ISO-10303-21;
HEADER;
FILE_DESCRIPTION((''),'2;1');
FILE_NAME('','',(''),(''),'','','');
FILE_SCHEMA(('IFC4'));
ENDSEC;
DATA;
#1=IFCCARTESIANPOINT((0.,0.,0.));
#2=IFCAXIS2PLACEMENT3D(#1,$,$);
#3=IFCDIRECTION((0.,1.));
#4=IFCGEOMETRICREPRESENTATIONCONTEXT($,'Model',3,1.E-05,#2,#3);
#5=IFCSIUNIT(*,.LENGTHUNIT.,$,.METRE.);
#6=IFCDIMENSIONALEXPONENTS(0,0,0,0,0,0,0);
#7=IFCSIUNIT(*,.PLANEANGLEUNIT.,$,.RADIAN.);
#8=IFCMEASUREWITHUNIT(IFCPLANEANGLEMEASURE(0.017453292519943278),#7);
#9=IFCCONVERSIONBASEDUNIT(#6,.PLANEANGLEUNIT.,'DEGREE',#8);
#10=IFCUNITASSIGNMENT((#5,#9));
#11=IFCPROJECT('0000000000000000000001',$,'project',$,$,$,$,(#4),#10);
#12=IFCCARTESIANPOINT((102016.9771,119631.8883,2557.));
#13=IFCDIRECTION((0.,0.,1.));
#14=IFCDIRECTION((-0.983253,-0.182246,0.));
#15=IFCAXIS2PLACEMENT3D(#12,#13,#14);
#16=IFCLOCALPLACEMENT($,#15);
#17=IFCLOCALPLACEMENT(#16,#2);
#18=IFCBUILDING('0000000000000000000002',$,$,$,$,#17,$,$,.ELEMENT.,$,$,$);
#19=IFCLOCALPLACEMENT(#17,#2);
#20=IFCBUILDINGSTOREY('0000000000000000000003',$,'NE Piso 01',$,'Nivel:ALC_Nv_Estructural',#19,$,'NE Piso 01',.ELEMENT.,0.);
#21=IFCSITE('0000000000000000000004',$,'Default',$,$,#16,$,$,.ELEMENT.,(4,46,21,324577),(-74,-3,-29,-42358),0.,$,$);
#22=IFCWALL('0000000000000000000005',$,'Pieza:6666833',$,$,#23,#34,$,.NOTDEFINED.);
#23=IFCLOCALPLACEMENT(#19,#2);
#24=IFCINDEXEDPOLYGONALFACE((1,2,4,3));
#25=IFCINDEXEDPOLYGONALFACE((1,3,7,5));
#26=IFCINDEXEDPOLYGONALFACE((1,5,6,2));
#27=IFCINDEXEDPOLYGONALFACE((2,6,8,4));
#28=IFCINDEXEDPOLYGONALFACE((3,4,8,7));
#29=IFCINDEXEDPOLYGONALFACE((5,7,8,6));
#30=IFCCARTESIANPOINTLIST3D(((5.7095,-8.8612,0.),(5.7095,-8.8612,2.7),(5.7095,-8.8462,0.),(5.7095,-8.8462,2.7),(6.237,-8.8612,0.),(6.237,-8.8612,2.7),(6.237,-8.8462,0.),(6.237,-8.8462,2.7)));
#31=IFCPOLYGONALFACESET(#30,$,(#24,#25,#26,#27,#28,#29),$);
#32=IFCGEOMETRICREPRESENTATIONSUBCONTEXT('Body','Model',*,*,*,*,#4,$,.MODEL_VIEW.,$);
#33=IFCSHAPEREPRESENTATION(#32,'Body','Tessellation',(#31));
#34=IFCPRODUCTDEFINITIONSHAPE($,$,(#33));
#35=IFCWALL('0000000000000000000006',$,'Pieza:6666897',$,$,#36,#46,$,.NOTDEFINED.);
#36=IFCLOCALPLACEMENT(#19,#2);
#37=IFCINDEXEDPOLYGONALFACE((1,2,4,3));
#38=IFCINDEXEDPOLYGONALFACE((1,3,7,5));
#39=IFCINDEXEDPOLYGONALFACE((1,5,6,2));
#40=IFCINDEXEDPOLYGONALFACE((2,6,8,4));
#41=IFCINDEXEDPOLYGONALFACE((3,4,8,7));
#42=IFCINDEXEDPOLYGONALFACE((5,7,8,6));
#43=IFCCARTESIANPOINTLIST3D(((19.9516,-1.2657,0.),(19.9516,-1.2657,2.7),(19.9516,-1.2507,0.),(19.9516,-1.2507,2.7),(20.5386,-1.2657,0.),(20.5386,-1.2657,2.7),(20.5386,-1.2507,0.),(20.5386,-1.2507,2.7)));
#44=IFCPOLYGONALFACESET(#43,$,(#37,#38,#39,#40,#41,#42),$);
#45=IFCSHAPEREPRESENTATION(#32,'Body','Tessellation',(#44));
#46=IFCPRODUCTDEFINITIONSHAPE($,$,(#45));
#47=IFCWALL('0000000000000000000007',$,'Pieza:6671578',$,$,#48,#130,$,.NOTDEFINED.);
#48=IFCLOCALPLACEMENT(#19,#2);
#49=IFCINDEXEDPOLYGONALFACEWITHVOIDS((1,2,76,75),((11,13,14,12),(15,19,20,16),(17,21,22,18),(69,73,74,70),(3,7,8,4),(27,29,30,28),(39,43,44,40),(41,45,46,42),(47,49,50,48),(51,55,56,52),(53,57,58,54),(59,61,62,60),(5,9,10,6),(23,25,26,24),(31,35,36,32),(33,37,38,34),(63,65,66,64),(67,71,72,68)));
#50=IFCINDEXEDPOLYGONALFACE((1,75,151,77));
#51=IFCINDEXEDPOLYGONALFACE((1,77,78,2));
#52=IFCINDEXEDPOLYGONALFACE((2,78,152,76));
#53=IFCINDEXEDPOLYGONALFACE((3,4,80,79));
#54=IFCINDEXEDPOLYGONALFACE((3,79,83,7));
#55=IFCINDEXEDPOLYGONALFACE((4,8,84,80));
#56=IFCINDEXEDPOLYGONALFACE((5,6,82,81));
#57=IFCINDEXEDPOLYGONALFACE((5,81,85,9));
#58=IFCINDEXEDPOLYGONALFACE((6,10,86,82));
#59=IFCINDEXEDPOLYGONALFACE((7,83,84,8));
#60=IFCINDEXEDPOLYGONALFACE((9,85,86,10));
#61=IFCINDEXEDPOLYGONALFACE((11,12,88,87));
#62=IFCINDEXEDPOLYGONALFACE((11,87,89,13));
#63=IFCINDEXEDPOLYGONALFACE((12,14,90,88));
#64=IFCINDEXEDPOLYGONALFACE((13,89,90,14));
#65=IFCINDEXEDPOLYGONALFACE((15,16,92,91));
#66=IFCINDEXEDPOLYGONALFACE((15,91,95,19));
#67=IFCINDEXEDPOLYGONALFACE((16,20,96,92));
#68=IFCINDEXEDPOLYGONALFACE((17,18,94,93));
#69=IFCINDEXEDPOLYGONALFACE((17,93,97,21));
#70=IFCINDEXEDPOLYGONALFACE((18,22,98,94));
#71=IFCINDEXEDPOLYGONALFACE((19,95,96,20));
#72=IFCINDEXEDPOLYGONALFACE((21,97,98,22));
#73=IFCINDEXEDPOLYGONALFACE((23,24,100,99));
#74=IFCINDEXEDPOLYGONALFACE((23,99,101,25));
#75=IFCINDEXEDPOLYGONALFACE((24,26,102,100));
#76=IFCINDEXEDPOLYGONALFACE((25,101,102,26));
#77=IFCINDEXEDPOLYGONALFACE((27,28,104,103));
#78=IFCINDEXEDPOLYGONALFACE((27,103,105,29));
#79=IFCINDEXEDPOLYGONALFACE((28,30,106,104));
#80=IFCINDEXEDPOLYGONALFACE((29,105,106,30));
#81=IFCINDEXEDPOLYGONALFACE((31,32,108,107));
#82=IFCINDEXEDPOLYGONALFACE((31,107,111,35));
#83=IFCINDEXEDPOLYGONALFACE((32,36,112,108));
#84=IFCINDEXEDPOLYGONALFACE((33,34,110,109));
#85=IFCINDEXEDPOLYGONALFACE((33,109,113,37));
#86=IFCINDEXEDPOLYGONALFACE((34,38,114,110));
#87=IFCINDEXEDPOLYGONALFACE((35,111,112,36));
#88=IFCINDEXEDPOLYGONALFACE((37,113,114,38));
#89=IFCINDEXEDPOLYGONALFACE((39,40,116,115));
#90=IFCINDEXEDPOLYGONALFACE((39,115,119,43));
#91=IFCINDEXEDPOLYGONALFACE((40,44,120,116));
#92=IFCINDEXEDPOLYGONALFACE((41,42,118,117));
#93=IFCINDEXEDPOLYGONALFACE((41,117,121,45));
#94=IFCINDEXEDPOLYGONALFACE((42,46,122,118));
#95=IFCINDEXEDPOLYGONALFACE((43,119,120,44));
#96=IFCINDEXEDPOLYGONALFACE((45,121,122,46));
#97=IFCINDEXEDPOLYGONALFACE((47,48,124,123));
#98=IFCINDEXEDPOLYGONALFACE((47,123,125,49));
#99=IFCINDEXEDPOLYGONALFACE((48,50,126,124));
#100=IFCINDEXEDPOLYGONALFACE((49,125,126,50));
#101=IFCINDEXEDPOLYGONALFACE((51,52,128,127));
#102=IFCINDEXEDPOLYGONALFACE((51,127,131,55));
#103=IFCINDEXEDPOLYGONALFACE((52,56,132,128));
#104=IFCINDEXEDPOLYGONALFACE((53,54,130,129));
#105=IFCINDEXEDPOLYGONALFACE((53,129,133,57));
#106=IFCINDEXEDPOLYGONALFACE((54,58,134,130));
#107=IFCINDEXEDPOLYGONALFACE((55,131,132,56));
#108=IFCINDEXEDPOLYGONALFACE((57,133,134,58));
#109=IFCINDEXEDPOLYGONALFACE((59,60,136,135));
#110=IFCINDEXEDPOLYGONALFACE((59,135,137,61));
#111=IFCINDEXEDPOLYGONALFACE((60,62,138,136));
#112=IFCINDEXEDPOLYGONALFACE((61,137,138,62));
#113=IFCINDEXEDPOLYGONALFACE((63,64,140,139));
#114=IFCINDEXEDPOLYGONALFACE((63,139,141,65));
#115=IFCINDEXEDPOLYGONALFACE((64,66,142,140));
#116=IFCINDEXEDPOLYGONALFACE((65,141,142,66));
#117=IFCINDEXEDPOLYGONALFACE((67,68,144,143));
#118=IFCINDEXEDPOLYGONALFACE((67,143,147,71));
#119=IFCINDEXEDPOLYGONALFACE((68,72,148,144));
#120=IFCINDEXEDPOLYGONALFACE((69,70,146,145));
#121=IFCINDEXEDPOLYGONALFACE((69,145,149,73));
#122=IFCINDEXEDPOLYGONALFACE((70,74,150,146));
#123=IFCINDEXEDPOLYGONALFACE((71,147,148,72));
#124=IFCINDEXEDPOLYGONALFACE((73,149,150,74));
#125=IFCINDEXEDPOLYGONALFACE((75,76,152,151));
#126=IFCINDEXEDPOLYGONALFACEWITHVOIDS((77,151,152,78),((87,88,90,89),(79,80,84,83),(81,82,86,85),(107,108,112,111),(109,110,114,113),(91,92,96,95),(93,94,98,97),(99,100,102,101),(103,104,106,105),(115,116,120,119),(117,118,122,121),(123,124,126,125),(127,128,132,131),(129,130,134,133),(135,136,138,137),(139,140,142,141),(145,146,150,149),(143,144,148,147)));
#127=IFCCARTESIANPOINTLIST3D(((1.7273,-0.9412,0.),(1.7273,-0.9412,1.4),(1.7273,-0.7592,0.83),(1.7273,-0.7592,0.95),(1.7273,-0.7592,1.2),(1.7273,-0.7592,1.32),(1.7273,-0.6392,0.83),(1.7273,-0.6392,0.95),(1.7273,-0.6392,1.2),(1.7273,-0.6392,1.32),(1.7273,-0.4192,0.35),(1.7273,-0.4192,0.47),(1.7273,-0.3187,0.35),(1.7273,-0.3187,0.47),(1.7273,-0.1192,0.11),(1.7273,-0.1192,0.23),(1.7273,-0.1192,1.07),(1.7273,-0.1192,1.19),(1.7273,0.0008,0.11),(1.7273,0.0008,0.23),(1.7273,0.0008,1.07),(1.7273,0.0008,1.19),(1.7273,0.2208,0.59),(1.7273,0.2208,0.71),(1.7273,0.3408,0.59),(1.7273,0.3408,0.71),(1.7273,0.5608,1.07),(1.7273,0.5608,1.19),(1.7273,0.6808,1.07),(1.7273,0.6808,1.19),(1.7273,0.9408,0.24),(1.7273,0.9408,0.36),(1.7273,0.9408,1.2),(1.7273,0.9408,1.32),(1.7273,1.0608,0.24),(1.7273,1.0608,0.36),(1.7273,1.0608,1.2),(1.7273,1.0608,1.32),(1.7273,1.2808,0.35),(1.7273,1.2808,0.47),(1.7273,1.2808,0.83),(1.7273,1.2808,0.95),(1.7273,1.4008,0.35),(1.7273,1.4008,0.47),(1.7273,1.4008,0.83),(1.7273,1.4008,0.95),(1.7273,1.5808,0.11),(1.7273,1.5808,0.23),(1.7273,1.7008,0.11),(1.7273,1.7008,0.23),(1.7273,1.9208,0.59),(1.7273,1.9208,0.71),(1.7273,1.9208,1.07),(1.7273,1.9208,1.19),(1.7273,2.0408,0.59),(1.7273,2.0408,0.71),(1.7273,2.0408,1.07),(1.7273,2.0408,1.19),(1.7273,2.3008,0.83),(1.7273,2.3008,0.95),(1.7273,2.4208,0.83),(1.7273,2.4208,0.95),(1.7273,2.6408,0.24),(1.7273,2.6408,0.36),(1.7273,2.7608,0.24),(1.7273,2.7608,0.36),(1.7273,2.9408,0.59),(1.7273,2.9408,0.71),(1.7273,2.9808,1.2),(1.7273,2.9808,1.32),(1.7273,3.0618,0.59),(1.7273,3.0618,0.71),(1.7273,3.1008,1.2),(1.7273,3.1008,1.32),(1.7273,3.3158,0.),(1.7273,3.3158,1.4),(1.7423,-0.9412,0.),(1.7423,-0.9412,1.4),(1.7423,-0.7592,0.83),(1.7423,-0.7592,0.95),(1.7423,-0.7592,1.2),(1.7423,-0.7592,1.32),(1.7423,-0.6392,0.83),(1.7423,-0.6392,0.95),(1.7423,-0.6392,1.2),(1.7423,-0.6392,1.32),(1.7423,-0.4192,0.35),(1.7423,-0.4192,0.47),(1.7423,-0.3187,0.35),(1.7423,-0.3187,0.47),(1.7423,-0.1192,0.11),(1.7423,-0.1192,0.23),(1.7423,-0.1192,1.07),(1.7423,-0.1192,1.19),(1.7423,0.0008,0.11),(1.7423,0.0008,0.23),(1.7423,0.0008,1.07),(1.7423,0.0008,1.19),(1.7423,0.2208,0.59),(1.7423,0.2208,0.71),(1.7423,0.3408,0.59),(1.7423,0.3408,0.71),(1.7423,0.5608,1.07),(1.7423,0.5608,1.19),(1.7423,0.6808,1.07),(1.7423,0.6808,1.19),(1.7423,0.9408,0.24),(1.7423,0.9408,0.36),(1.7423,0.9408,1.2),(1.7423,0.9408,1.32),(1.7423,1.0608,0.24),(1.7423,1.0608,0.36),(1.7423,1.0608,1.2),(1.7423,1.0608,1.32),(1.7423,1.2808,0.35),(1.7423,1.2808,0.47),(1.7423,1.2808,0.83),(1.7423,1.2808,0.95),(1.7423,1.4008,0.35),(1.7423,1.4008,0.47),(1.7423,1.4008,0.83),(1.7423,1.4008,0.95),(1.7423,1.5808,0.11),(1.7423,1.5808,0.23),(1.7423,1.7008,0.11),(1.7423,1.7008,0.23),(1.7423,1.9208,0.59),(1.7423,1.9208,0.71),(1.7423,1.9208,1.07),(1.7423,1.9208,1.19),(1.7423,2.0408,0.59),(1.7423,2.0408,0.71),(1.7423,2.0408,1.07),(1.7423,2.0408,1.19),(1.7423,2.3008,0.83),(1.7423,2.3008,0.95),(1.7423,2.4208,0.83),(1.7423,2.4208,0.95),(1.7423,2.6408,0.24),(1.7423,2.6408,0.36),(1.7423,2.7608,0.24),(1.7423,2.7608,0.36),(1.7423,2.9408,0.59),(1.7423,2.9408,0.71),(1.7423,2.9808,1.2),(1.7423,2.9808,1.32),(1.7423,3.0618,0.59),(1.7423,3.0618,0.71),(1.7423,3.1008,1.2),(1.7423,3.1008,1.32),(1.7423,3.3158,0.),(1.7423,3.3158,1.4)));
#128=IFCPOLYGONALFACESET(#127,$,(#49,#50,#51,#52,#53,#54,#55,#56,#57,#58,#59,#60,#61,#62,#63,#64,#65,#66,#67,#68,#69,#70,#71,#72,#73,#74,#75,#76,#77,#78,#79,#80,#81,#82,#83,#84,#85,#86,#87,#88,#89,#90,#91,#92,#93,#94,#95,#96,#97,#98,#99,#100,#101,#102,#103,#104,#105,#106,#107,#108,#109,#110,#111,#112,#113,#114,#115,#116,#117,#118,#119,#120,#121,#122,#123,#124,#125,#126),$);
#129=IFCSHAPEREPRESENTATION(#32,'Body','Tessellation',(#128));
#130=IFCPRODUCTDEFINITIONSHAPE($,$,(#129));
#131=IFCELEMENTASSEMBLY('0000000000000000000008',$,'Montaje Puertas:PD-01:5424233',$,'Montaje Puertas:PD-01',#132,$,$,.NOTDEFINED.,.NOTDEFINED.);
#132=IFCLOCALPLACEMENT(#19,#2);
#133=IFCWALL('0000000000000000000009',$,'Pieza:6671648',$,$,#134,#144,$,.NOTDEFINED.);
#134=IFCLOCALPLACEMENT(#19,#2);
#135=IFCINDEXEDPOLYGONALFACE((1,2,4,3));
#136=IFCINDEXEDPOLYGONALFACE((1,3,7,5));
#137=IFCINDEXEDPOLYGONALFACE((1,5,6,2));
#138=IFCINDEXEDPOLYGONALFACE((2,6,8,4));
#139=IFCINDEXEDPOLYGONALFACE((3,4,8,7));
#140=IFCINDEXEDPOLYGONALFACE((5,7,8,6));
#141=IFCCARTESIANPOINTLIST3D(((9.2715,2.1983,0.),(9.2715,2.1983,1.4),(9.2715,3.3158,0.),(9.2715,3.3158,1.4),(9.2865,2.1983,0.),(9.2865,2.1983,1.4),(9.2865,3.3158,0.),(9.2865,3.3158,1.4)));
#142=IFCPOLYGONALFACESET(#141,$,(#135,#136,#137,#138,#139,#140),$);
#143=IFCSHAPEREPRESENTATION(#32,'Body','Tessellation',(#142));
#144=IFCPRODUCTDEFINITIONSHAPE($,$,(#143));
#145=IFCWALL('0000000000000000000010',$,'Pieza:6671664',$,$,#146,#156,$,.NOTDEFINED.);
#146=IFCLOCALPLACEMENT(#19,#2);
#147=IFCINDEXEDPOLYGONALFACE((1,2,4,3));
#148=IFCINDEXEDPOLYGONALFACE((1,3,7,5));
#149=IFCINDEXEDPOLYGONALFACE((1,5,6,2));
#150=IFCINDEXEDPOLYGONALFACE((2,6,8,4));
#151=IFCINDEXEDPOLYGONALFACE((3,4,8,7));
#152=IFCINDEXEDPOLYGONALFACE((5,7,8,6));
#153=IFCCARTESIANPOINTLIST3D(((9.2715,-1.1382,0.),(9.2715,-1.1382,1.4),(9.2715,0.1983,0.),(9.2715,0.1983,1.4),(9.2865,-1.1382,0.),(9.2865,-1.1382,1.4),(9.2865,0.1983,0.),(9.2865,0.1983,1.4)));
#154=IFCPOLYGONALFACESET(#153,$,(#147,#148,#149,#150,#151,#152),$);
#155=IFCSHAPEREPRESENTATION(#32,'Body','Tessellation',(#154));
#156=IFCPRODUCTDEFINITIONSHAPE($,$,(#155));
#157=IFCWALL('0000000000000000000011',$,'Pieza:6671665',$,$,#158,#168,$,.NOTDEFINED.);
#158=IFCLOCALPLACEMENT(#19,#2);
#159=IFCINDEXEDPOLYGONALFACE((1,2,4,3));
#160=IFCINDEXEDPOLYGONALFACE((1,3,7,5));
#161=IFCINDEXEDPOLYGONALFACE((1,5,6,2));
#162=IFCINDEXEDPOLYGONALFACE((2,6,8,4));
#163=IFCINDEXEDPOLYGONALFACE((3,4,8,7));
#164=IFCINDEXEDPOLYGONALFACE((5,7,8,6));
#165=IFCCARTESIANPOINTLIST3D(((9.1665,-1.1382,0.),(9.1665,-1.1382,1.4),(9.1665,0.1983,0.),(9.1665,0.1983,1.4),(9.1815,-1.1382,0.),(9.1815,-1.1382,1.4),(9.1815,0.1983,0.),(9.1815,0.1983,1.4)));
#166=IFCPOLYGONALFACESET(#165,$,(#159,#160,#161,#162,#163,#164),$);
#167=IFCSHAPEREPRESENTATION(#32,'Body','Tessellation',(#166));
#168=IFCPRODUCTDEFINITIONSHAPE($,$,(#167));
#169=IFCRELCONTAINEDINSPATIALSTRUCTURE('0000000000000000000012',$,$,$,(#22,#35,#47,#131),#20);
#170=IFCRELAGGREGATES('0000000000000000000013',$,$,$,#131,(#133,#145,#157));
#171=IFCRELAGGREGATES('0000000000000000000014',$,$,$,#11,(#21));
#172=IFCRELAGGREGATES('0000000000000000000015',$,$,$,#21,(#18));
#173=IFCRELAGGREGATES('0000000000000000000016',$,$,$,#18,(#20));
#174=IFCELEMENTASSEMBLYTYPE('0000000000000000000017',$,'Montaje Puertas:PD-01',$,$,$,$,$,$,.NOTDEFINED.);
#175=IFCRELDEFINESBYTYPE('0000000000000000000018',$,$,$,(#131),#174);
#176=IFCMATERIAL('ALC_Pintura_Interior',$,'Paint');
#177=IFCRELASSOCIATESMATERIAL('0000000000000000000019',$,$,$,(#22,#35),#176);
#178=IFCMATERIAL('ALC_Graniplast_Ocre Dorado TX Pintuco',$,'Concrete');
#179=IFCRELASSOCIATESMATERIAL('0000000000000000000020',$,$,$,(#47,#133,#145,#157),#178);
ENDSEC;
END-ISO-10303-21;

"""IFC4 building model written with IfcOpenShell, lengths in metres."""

from ifc_helpers import new_model, entity, si_unit, converted_unit, direction, frame, frame_2d, origin, origin_2d_with_axis, place, context, subcontext, project, spatial, rectangle, extrude, boolean, material, type_object, element, aggregate, save


model = new_model("IFC4")

# Units and contexts
model_context = context("Model", 3, precision=1e-05, world=origin(), true_north=direction((0.0, 1.0)))
body_context = subcontext(model_context, "Body", "Model", "MODEL_VIEW")
ifc_project = project(units=[si_unit("LENGTHUNIT", "METRE"), converted_unit("PLANEANGLEUNIT", "DEGREE", entity("IfcPlaneAngleMeasure", 0.017453292519943278), si_unit("PLANEANGLEUNIT", "RADIAN"), dimensions=[0, 0, 0, 0, 0, 0, 0])], contexts=[model_context])

# Site, building, storey
site_placement = place(None, frame((102016.9771, 119631.8883, 2557.0), z_axis=(0.0, 0.0, 1.0), x_axis=(-0.983253, -0.182246, 0.0)))
site = spatial("IfcSite", under=ifc_project, at=site_placement, Name="Default", CompositionType="ELEMENT", RefLatitude=(4, 46, 21, 324577), RefLongitude=(-74, -3, -29, -42358), RefElevation=0.0)
building_placement = place(site_placement, origin())
building = spatial("IfcBuilding", under=site, at=building_placement, CompositionType="ELEMENT")
storey_placement = place(building_placement, origin())
storey = spatial("IfcBuildingStorey", under=building, at=storey_placement, Name="NE Piso 01", ObjectType="Nivel:ALC_Nv_Estructural", LongName="NE Piso 01", CompositionType="ELEMENT", Elevation=0.0)

# Walls
ifc_material_1 = material(Name="ALC_Pintura_Interior", Category="Paint")
wall_1_placement = place(storey_placement, origin())
element("IfcWall", 1, at=wall_1_placement, inside=storey, material=ifc_material_1, Name="Pieza:6666833", PredefinedType="NOTDEFINED", context=body_context, shape_type="SweptSolid", body=[
    extrude(rectangle(XDim=0.015, YDim=0.5275, at=frame_2d((0.0, 0.0), x_axis=(1.0, 0.0))), frame((5.9733, -8.8537, 0.0), z_axis=(0.0, 0.0, 1.0), x_axis=(0.0, -1.0, 0.0)), (0.0, 0.0, 1.0), 2.7),
])
wall_2_placement = place(storey_placement, origin())
element("IfcWall", 2, at=wall_2_placement, inside=storey, material=ifc_material_1, Name="Pieza:6666897", PredefinedType="NOTDEFINED", context=body_context, shape_type="SweptSolid", body=[
    extrude(rectangle(XDim=0.015, YDim=0.587, at=frame_2d((0.0, 0.0), x_axis=(1.0, 0.0))), frame((20.2451, -1.2582, 0.0), z_axis=(0.0, 0.0, 1.0), x_axis=(0.0, -1.0, 0.0)), (0.0, 0.0, 1.0), 2.7),
])
ifc_material_2 = material(Name="ALC_Graniplast_Ocre Dorado TX Pintuco", Category="Concrete")
wall_3_placement = place(storey_placement, origin())
solid_1 = boolean("DIFFERENCE", boolean("DIFFERENCE", boolean("DIFFERENCE", boolean("DIFFERENCE", boolean("DIFFERENCE", boolean("DIFFERENCE", boolean("DIFFERENCE", boolean("DIFFERENCE", extrude(rectangle(XDim=0.015, YDim=4.257, at=origin_2d_with_axis()), frame((1.7348, 1.1873, 0.0)), (0.0, 0.0, 1.0), 1.4), extrude(rectangle(XDim=0.12, YDim=0.12, at=frame_2d((0.0, 0.0), x_axis=(0.0, 1.0))), frame((1.7273, -0.0592, 0.17), z_axis=(-1.0, 0.0, 0.0), x_axis=(0.0, 1.0, 0.0)), (0.0, 0.0, -1.0), 0.015)), extrude(rectangle(XDim=0.12, YDim=0.12, at=frame_2d((0.0, 0.0), x_axis=(0.0, 1.0))), frame((1.7273, 1.6408, 0.17), z_axis=(-1.0, 0.0, 0.0), x_axis=(0.0, 1.0, 0.0)), (0.0, 0.0, -1.0), 0.015)), extrude(rectangle(XDim=0.12, YDim=0.12, at=frame_2d((0.0, 0.0), x_axis=(0.0, 1.0))), frame((1.7273, 1.0008, 0.3), z_axis=(-1.0, 0.0, 0.0), x_axis=(0.0, 1.0, 0.0)), (0.0, 0.0, -1.0), 0.015)), extrude(rectangle(XDim=0.12, YDim=0.12, at=frame_2d((0.0, 0.0), x_axis=(0.0, 1.0))), frame((1.7273, 2.7008, 0.3), z_axis=(-1.0, 0.0, 0.0), x_axis=(0.0, 1.0, 0.0)), (0.0, 0.0, -1.0), 0.015)), extrude(rectangle(XDim=0.12, YDim=0.1005, at=frame_2d((0.0, 0.0), x_axis=(0.0, 1.0))), frame((1.7273, -0.3689, 0.41), z_axis=(-1.0, 0.0, 0.0), x_axis=(0.0, 1.0, 0.0)), (0.0, 0.0, -1.0), 0.015)), extrude(rectangle(XDim=0.12, YDim=0.12, at=frame_2d((0.0, 0.0), x_axis=(0.0, 1.0))), frame((1.7273, 1.3408, 0.41), z_axis=(-1.0, 0.0, 0.0), x_axis=(0.0, 1.0, 0.0)), (0.0, 0.0, -1.0), 0.015)), extrude(rectangle(XDim=0.12, YDim=0.12, at=frame_2d((0.0, 0.0), x_axis=(0.0, 1.0))), frame((1.7273, 0.2808, 0.65), z_axis=(-1.0, 0.0, 0.0), x_axis=(0.0, 1.0, 0.0)), (0.0, 0.0, -1.0), 0.015)), extrude(rectangle(XDim=0.12, YDim=0.12, at=frame_2d((0.0, 0.0), x_axis=(0.0, 1.0))), frame((1.7273, 1.9808, 0.65), z_axis=(1.0, 0.0, 0.0), x_axis=(0.0, -1.0, 0.0)), (0.0, 0.0, 1.0), 0.015))
solid_2 = boolean("DIFFERENCE", boolean("DIFFERENCE", boolean("DIFFERENCE", boolean("DIFFERENCE", boolean("DIFFERENCE", boolean("DIFFERENCE", boolean("DIFFERENCE", boolean("DIFFERENCE", solid_1, extrude(rectangle(XDim=0.12, YDim=0.121, at=frame_2d((0.0, 0.0), x_axis=(0.0, 1.0))), frame((1.7273, 3.0013, 0.65), z_axis=(-1.0, 0.0, 0.0), x_axis=(0.0, 1.0, 0.0)), (0.0, 0.0, -1.0), 0.015)), extrude(rectangle(XDim=0.12, YDim=0.12, at=frame_2d((0.0, 0.0), x_axis=(0.0, 1.0))), frame((1.7273, -0.6992, 0.89), z_axis=(1.0, 0.0, 0.0), x_axis=(0.0, -1.0, 0.0)), (0.0, 0.0, 1.0), 0.015)), extrude(rectangle(XDim=0.12, YDim=0.12, at=frame_2d((0.0, 0.0), x_axis=(0.0, 1.0))), frame((1.7273, 1.3408, 0.89), z_axis=(-1.0, 0.0, 0.0), x_axis=(0.0, 1.0, 0.0)), (0.0, 0.0, -1.0), 0.015)), extrude(rectangle(XDim=0.12, YDim=0.12, at=frame_2d((0.0, 0.0), x_axis=(0.0, 1.0))), frame((1.7273, 2.3608, 0.89), z_axis=(-1.0, 0.0, 0.0), x_axis=(0.0, 1.0, 0.0)), (0.0, 0.0, -1.0), 0.015)), extrude(rectangle(XDim=0.12, YDim=0.12, at=frame_2d((0.0, 0.0), x_axis=(0.0, 1.0))), frame((1.7273, -0.0592, 1.13), z_axis=(-1.0, 0.0, 0.0), x_axis=(0.0, 1.0, 0.0)), (0.0, 0.0, -1.0), 0.015)), extrude(rectangle(XDim=0.12, YDim=0.12, at=frame_2d((0.0, 0.0), x_axis=(0.0, 1.0))), frame((1.7273, 0.6208, 1.13), z_axis=(-1.0, 0.0, 0.0), x_axis=(0.0, 1.0, 0.0)), (0.0, 0.0, -1.0), 0.015)), extrude(rectangle(XDim=0.12, YDim=0.12, at=frame_2d((0.0, 0.0), x_axis=(0.0, 1.0))), frame((1.7273, 1.9808, 1.13), z_axis=(-1.0, 0.0, 0.0), x_axis=(0.0, 1.0, 0.0)), (0.0, 0.0, -1.0), 0.015)), extrude(rectangle(XDim=0.12, YDim=0.12, at=frame_2d((0.0, 0.0), x_axis=(0.0, 1.0))), frame((1.7273, -0.6992, 1.26), z_axis=(-1.0, 0.0, 0.0), x_axis=(0.0, 1.0, 0.0)), (0.0, 0.0, -1.0), 0.015))
element("IfcWall", 3, at=wall_3_placement, inside=storey, material=ifc_material_2, Name="Pieza:6671578", PredefinedType="NOTDEFINED", context=body_context, shape_type="SweptSolid", body=[
    boolean("DIFFERENCE", boolean("DIFFERENCE", solid_2, extrude(rectangle(XDim=0.12, YDim=0.12, at=frame_2d((0.0, 0.0), x_axis=(0.0, 1.0))), frame((1.7273, 1.0008, 1.26), z_axis=(-1.0, 0.0, 0.0), x_axis=(0.0, 1.0, 0.0)), (0.0, 0.0, -1.0), 0.015)), extrude(rectangle(XDim=0.12, YDim=0.12, at=frame_2d((0.0, 0.0), x_axis=(0.0, 1.0))), frame((1.7273, 3.0408, 1.26), z_axis=(-1.0, 0.0, 0.0), x_axis=(0.0, 1.0, 0.0)), (0.0, 0.0, -1.0), 0.015)),
])

# Element assembly, walls
element_assembly_type = type_object("IfcElementAssemblyType", Name="Montaje Puertas:PD-01", PredefinedType="NOTDEFINED")
assembly_placement = place(storey_placement, origin())
assembly = element("IfcElementAssembly", 4, at=assembly_placement, inside=storey, type_object=element_assembly_type, Name="Montaje Puertas:PD-01:5424233", ObjectType="Montaje Puertas:PD-01", AssemblyPlace="NOTDEFINED", PredefinedType="NOTDEFINED")
wall_4_placement = place(assembly_placement, origin())
wall_4 = element("IfcWall", 5, at=wall_4_placement, material=ifc_material_2, Name="Pieza:6671648", PredefinedType="NOTDEFINED", context=body_context, shape_type="SweptSolid", body=[
    extrude(rectangle(XDim=1.1175, YDim=0.015, at=frame_2d((0.0, 0.0), x_axis=(1.0, 0.0))), frame((9.279, 2.7571, 0.0), z_axis=(0.0, 0.0, 1.0), x_axis=(0.0, -1.0, 0.0)), (0.0, 0.0, 1.0), 1.4),
])
wall_5_placement = place(assembly_placement, origin())
wall_5 = element("IfcWall", 6, at=wall_5_placement, material=ifc_material_2, Name="Pieza:6671664", PredefinedType="NOTDEFINED", context=body_context, shape_type="SweptSolid", body=[
    extrude(rectangle(XDim=1.3365, YDim=0.015, at=origin_2d_with_axis()), frame((9.279, -0.4699, 0.0), z_axis=(0.0, 0.0, 1.0), x_axis=(0.0, -1.0, 0.0)), (0.0, 0.0, 1.0), 1.4),
])
wall_6_placement = place(assembly_placement, origin())
wall_6 = element("IfcWall", 7, at=wall_6_placement, material=ifc_material_2, Name="Pieza:6671665", PredefinedType="NOTDEFINED", context=body_context, shape_type="SweptSolid", body=[
    extrude(rectangle(XDim=1.3365, YDim=0.015, at=frame_2d((0.0, 0.0), x_axis=(1.0, 0.0))), frame((9.174, -0.4699, 0.0), z_axis=(0.0, 0.0, 1.0), x_axis=(0.0, -1.0, 0.0)), (0.0, 0.0, 1.0), 1.4),
])
aggregate(assembly, [wall_4, wall_5, wall_6])

save(model, "model.ifc")
